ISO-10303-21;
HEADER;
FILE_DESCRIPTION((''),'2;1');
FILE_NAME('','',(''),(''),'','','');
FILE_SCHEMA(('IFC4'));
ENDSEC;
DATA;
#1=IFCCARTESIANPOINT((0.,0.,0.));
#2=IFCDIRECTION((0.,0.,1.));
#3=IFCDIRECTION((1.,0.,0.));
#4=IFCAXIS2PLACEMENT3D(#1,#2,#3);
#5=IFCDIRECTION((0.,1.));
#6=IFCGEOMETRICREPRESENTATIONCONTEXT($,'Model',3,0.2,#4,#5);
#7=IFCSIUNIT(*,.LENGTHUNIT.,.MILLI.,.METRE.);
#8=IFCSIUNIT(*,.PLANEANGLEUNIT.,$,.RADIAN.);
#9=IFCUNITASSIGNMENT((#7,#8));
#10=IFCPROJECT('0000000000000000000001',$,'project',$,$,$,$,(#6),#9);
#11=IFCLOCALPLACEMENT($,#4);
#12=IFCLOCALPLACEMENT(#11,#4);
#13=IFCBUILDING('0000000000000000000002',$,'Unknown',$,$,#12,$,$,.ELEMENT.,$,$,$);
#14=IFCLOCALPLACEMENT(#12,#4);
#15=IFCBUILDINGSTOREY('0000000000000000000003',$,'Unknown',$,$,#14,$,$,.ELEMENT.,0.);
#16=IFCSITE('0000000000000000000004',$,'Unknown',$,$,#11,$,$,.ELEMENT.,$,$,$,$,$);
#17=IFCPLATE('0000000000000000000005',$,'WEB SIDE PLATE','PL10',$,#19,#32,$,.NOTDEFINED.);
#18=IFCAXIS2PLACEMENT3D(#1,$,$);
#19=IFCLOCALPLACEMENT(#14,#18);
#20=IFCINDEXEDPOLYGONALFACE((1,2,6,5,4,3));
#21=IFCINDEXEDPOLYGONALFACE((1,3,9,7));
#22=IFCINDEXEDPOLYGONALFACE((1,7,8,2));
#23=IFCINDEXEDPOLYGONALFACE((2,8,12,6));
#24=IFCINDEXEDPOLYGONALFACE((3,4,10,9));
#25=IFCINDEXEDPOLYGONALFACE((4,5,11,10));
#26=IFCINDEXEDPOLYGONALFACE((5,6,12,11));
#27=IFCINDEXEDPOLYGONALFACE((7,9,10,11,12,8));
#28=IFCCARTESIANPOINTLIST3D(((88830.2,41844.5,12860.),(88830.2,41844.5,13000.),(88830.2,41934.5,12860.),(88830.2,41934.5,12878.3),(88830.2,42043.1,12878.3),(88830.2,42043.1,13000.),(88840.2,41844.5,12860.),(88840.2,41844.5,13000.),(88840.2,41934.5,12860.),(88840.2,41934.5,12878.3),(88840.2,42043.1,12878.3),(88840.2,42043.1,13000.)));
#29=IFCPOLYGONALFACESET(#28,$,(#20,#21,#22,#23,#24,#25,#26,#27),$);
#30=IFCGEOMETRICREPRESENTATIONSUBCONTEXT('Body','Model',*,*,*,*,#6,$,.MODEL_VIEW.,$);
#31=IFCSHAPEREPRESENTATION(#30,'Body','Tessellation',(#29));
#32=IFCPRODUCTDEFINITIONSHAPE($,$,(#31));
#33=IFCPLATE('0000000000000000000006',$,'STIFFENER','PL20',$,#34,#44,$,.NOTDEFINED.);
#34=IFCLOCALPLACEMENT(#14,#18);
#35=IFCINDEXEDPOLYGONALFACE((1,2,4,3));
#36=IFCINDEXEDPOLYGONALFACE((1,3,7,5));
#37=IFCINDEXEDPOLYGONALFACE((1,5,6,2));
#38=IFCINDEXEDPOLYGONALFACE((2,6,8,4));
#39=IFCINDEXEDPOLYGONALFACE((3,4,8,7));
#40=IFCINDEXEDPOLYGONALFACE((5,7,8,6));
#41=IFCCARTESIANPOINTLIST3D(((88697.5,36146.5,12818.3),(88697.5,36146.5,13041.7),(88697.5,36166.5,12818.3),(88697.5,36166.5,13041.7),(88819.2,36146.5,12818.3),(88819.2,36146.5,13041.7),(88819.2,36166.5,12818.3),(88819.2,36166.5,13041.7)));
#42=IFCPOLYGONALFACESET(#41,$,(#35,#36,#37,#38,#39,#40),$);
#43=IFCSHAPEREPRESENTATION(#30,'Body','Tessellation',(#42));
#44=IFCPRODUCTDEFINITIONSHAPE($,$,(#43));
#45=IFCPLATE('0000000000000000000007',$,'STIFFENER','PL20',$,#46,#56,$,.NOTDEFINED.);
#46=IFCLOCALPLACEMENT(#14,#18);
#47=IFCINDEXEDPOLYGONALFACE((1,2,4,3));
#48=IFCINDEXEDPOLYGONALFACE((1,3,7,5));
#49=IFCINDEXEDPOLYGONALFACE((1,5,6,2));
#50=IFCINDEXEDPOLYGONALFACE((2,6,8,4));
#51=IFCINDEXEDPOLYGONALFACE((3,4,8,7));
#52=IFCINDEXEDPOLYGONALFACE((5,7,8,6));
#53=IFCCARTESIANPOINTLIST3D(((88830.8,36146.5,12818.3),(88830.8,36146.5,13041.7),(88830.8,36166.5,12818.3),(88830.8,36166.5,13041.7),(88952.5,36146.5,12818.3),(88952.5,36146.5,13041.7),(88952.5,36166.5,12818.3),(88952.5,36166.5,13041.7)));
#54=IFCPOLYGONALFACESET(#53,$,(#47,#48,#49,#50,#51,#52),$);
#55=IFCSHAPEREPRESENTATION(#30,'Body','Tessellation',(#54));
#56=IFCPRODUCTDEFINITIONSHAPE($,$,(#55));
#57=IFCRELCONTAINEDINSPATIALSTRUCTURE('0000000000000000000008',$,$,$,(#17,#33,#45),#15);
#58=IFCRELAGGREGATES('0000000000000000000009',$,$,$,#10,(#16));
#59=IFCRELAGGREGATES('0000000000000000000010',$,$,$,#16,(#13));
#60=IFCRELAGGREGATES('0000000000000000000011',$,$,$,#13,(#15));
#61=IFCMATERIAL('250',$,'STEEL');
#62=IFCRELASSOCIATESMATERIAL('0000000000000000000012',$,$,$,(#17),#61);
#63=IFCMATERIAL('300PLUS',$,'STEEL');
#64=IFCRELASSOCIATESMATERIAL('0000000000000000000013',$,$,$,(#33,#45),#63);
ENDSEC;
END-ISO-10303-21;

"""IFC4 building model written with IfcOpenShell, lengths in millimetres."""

from ifc_helpers import new_model, si_unit, direction, frame, origin_with_axes, place, context, subcontext, project, spatial, line, indexed_curve, outline, extrude, material, element, save


model = new_model("IFC4")

# Units and contexts
model_context = context("Model", 3, precision=0.2, world=origin_with_axes(), true_north=direction((0.0, 1.0)))
body_context = subcontext(model_context, "Body", "Model", "MODEL_VIEW")
ifc_project = project(units=[si_unit("LENGTHUNIT", "METRE", prefix="MILLI"), si_unit("PLANEANGLEUNIT", "RADIAN")], contexts=[model_context])

# Site, building, storey
site_placement = place(None, origin_with_axes())
site = spatial("IfcSite", under=ifc_project, at=site_placement, Name="Unknown", CompositionType="ELEMENT")
building_placement = place(site_placement, origin_with_axes())
building = spatial("IfcBuilding", under=site, at=building_placement, Name="Unknown", CompositionType="ELEMENT")
storey_placement = place(building_placement, origin_with_axes())
storey = spatial("IfcBuildingStorey", under=building, at=storey_placement, Name="Unknown", CompositionType="ELEMENT", Elevation=0.0)

# Shared definitions
ifc_material_1 = material(Name="300PLUS", Category="STEEL")

# Plates
ifc_material_2 = material(Name="250", Category="STEEL")
plate_1_placement = place(storey_placement, frame((88835.2, 41934.5, 12860.0), z_axis=(1.0, 0.0, 0.0), x_axis=(0.0, 0.0, 1.0)))
element("IfcPlate", 1, at=plate_1_placement, inside=storey, material=ifc_material_2, Name="WEB SIDE PLATE", Description="PL10", PredefinedType="NOTDEFINED", context=body_context, shape_type="SolidModel", body=[
    extrude(outline(indexed_curve([(0.0, 0.0), (18.3, 0.0), (18.3, -108.6), (140.0, -108.6), (140.0, 90.0), (0.0, 90.0)], segments=[line(1, 2, 3, 4, 5, 6, 1)])), frame((0.0, 0.0, 5.0), z_axis=(0.0, 0.0, 1.0), x_axis=(1.0, 0.0, 0.0)), (0.0, 0.0, -1.0), 10.0),
])
for number, where, z_axis, x_axis, name in (
    (2, (88697.5, 36156.5, 12818.3), (0.0, 1.0, 0.0), (0.0, 0.0, 1.0), "STIFFENER"),
    (3, (88830.8, 36156.5, 12818.3), (0.0, 1.0, 0.0), (0.0, 0.0, 1.0), "STIFFENER"),
):
    element("IfcPlate", number, at=place(storey_placement, frame(where, z_axis=z_axis, x_axis=x_axis)), inside=storey, material=ifc_material_1, Name=name, Description="PL20", PredefinedType="NOTDEFINED", context=body_context, shape_type="SolidModel", body=[
        extrude(outline(indexed_curve([(0.0, 0.0), (223.4, 0.0), (223.4, 121.7), (0.0, 121.7)], segments=[line(1, 2, 3, 4, 1)])), frame((0.0, 0.0, 10.0), z_axis=(0.0, 0.0, 1.0), x_axis=(1.0, 0.0, 0.0)), (0.0, 0.0, -1.0), 20.0),
    ])

save(model, "model.ifc")
